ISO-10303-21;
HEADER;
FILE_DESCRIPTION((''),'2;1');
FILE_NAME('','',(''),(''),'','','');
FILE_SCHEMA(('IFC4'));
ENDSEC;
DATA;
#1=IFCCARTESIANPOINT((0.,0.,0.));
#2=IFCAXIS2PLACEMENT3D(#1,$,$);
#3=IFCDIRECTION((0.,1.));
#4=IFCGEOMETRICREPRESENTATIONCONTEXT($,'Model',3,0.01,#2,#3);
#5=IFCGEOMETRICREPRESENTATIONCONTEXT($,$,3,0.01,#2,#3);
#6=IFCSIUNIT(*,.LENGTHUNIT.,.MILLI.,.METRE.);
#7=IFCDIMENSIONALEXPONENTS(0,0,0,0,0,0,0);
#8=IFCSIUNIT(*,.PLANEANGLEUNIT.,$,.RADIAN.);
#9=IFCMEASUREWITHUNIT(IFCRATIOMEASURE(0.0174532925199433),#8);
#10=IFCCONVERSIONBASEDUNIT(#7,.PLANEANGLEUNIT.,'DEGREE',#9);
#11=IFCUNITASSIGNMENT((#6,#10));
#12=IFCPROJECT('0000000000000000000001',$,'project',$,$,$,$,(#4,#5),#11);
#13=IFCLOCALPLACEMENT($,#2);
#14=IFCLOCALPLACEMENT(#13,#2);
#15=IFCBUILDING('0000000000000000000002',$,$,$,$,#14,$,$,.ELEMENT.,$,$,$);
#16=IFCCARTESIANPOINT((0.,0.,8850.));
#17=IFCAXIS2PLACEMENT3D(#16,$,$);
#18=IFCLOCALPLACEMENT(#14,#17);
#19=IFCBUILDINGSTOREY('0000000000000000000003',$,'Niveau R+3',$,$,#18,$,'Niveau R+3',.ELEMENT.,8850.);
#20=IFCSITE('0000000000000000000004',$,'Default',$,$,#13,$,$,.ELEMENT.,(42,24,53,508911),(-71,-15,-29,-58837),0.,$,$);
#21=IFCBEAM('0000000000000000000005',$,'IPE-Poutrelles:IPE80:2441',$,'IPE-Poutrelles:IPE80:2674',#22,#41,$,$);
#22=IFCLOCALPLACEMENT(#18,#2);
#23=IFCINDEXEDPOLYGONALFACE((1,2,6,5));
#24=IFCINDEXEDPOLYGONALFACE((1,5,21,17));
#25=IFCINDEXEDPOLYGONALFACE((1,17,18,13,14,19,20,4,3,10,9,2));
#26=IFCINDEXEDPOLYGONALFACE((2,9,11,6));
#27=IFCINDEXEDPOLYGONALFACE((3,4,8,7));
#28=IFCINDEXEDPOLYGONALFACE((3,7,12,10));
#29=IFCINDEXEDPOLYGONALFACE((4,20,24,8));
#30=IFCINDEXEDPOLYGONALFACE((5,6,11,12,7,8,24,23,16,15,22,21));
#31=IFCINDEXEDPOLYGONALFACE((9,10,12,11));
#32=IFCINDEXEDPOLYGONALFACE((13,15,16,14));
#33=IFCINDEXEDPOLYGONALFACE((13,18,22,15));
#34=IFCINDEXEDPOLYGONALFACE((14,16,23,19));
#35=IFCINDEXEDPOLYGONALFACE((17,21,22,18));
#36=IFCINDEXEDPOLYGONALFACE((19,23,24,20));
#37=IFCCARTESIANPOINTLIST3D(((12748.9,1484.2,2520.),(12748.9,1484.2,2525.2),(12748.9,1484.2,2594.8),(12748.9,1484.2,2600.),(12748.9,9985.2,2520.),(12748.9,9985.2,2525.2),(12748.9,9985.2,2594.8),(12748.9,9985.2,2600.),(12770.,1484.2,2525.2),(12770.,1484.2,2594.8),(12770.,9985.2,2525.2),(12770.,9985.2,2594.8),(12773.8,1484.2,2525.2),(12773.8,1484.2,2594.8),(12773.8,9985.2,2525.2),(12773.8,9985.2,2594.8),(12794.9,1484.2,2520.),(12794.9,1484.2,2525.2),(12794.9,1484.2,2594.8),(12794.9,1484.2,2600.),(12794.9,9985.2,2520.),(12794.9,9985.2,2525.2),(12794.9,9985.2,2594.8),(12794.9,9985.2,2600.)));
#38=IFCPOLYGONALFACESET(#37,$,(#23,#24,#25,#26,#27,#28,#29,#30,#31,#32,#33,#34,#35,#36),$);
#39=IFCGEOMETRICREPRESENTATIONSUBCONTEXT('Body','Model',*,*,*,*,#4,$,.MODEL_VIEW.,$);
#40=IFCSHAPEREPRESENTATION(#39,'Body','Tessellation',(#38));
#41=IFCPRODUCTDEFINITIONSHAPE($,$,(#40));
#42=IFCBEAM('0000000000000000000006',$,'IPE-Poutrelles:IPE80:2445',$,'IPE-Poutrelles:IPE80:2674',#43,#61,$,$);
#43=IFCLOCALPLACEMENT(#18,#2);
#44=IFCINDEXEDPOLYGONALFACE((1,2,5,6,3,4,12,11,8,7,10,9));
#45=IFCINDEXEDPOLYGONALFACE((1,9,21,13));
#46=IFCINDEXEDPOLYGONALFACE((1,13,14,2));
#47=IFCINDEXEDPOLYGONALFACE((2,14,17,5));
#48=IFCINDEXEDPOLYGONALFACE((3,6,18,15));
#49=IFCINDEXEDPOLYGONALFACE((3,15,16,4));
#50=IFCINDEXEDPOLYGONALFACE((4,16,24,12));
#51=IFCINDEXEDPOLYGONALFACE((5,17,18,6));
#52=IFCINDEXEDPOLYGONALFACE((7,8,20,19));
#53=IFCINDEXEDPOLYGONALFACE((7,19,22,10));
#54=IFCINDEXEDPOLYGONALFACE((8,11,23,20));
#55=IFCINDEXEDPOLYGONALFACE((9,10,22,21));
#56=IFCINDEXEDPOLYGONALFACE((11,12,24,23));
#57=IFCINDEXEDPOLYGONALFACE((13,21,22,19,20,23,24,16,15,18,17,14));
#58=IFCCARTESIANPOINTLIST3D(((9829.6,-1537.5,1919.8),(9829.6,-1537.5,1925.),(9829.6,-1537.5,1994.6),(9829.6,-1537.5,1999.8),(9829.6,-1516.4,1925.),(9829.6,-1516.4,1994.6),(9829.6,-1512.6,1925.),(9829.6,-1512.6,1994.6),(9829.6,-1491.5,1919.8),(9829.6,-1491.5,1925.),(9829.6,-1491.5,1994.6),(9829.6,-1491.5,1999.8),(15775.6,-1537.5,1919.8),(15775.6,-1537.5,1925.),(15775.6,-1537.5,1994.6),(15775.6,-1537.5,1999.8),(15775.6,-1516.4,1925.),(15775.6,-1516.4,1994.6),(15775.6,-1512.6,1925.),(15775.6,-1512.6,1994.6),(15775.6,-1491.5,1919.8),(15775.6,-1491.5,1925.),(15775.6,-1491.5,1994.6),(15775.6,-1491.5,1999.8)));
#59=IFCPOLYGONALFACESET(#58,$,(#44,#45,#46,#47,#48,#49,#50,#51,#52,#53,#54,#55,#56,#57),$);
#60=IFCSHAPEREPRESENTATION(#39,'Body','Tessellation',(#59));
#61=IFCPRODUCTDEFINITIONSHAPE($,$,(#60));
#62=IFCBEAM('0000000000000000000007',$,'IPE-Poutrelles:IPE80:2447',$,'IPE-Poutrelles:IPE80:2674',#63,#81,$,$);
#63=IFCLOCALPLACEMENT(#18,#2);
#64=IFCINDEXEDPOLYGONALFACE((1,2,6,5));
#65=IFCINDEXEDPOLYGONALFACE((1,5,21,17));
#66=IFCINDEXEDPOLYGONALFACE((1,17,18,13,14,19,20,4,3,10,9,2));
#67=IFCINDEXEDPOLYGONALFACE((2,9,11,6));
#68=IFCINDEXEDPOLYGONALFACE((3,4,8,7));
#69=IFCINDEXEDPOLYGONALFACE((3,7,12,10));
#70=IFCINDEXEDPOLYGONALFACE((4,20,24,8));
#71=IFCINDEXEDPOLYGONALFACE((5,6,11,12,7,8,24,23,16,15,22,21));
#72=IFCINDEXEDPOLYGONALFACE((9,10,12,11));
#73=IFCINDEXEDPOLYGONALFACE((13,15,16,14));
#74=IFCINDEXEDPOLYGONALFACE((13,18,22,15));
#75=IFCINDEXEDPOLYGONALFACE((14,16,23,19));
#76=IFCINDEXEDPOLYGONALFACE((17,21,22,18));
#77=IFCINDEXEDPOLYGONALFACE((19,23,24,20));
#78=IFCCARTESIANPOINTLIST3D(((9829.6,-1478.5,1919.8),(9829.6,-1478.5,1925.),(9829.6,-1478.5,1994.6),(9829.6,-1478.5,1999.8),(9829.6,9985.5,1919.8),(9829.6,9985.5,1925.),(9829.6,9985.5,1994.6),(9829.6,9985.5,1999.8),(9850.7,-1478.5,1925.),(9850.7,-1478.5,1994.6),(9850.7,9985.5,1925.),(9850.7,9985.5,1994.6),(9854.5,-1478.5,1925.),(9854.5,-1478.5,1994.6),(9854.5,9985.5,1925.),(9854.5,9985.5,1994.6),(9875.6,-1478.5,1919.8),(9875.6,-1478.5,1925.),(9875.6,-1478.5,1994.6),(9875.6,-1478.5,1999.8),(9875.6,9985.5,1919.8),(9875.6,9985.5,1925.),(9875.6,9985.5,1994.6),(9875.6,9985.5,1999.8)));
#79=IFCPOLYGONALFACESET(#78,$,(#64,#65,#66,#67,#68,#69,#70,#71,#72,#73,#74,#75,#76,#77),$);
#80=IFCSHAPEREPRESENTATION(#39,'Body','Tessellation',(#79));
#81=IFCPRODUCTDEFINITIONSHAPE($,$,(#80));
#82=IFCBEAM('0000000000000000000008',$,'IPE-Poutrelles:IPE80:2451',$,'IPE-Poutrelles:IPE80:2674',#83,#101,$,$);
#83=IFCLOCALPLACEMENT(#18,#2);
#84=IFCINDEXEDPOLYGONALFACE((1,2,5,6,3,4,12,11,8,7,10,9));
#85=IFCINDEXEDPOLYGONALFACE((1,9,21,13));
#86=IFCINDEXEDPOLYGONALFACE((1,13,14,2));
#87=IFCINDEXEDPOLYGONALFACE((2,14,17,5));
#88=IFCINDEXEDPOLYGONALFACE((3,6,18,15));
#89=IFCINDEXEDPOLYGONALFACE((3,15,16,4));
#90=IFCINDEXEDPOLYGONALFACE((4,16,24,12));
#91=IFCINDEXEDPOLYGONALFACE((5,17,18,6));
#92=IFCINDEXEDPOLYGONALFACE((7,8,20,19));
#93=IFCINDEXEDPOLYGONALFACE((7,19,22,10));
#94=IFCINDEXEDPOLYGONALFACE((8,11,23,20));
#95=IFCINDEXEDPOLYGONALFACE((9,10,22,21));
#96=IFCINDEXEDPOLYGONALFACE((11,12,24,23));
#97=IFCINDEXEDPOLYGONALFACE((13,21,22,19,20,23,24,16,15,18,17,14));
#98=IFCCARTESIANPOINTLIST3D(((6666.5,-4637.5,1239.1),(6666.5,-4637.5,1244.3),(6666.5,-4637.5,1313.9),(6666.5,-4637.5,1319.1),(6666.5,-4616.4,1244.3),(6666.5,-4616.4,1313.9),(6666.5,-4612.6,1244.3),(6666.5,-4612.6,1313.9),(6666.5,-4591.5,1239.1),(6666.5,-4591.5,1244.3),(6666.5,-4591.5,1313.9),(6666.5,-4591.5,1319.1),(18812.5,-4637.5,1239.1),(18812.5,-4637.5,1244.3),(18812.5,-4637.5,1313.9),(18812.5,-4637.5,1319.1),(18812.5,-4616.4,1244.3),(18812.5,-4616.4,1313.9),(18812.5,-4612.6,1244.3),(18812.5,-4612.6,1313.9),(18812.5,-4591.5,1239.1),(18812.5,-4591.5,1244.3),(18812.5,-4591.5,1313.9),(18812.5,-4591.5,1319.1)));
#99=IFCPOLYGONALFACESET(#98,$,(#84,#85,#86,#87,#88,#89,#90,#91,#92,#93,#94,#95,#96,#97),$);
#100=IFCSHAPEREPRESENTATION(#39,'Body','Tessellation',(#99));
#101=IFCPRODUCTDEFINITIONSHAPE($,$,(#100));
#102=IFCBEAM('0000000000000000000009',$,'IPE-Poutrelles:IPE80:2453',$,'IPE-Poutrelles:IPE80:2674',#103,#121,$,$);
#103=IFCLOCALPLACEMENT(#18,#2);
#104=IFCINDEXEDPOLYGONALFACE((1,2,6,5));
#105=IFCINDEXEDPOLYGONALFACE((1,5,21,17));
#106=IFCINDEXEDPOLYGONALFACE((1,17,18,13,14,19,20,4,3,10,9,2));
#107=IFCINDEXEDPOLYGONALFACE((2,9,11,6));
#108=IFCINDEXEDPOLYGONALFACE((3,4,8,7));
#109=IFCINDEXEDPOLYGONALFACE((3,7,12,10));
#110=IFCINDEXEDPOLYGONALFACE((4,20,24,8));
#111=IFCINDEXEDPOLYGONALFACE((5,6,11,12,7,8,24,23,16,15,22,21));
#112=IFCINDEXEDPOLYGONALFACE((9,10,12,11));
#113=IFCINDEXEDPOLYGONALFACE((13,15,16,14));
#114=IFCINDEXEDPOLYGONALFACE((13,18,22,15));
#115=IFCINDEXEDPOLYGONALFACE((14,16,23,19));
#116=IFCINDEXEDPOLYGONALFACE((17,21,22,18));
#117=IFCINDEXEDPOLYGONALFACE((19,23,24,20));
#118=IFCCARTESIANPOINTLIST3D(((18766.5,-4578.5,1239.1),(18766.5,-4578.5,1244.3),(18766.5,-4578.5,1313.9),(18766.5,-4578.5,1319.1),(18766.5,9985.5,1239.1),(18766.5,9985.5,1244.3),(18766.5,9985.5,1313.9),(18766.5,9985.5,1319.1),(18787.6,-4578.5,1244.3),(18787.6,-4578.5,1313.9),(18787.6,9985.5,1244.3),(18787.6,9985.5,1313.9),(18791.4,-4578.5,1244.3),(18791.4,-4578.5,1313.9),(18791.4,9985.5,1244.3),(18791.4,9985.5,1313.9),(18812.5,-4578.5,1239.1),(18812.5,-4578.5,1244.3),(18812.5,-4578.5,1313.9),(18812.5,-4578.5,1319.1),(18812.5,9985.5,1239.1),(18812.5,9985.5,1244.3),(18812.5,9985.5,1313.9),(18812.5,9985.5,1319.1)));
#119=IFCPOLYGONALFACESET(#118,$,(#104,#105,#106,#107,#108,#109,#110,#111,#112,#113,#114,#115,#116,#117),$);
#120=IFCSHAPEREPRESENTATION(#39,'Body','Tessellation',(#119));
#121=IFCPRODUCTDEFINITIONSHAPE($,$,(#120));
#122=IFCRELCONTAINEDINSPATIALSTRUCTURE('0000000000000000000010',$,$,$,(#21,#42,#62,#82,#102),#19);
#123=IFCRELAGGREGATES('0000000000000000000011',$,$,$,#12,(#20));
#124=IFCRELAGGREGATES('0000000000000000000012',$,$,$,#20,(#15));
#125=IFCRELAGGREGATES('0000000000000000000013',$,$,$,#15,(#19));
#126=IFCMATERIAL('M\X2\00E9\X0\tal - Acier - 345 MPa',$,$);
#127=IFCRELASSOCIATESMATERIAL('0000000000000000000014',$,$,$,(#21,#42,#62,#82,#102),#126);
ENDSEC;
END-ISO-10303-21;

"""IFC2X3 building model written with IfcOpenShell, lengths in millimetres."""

from ifc_helpers import new_model, entity, si_unit, converted_unit, direction, frame, frame_2d, origin, place, context, subcontext, project, spatial, i_section, extrude, material, element, save


model = new_model("IFC2X3")

# Units and contexts
model_context = context("Model", 3, precision=0.01, world=origin(), true_north=direction((0.0, 1.0)))
context_of_model = context(None, 3, precision=0.01, world=origin(), true_north=direction((0.0, 1.0)))
body_context = subcontext(model_context, "Body", "Model", "MODEL_VIEW")
ifc_project = project(units=[si_unit("LENGTHUNIT", "METRE", prefix="MILLI"), converted_unit("PLANEANGLEUNIT", "DEGREE", entity("IfcRatioMeasure", 0.0174532925199433), si_unit("PLANEANGLEUNIT", "RADIAN"), dimensions=[0, 0, 0, 0, 0, 0, 0])], contexts=[model_context, context_of_model])

# Site, building, storey
site_placement = place(None, origin())
site = spatial("IfcSite", under=ifc_project, at=site_placement, Name="Default", CompositionType="ELEMENT", RefLatitude=(42, 24, 53, 508911), RefLongitude=(-71, -15, -29, -58837), RefElevation=0.0)
building_placement = place(site_placement, origin())
building = spatial("IfcBuilding", under=site, at=building_placement, CompositionType="ELEMENT")
storey_placement = place(building_placement, frame((0.0, 0.0, 8850.0)))
storey = spatial("IfcBuildingStorey", under=building, at=storey_placement, Name="Niveau R+3", LongName="Niveau R+3", CompositionType="ELEMENT", Elevation=8850.0)

# Shared definitions
ifc_material = material(Name="Métal - Acier - 345 MPa")

# Beams
beam_1_placement = place(storey_placement, frame((12771.9, 1447.0, 2600.0), z_axis=(0.0, 0.0, 1.0), x_axis=(0.0, 1.0, 0.0)))
element("IfcBeam", 1, at=beam_1_placement, inside=storey, material=ifc_material, Name="IPE-Poutrelles:IPE80:2441", ObjectType="IPE-Poutrelles:IPE80:2674", context=body_context, shape_type="SweptSolid", body=[
    extrude(i_section(OverallWidth=46.0, OverallDepth=80.0, WebThickness=3.8, FlangeThickness=5.2, at=frame_2d((0.0, 0.0), x_axis=(0.0, 1.0))), frame((37.2, 0.0, -40.0), z_axis=(1.0, 0.0, 0.0), x_axis=(0.0, 0.0, -1.0)), (0.0, 0.0, 1.0), 8501.0),
])
beam_2_placement = place(storey_placement, frame((15752.6, -1514.5, 1999.8), z_axis=(0.0, 0.0, 1.0), x_axis=(-1.0, 0.0, 0.0)))
element("IfcBeam", 2, at=beam_2_placement, inside=storey, material=ifc_material, Name="IPE-Poutrelles:IPE80:2445", ObjectType="IPE-Poutrelles:IPE80:2674", context=body_context, shape_type="SweptSolid", body=[
    extrude(i_section(OverallWidth=46.0, OverallDepth=80.0, WebThickness=3.8, FlangeThickness=5.2, at=frame_2d((0.0, 0.0), x_axis=(0.0, 1.0))), frame((-23.0, 0.0, -40.0), z_axis=(1.0, 0.0, 0.0), x_axis=(0.0, 0.0, -1.0)), (0.0, 0.0, 1.0), 5946.0),
])
beam_3_placement = place(storey_placement, frame((9852.6, -1514.5, 1999.8), z_axis=(0.0, 0.0, 1.0), x_axis=(0.0, 1.0, 0.0)))
element("IfcBeam", 3, at=beam_3_placement, inside=storey, material=ifc_material, Name="IPE-Poutrelles:IPE80:2447", ObjectType="IPE-Poutrelles:IPE80:2674", context=body_context, shape_type="SweptSolid", body=[
    extrude(i_section(OverallWidth=46.0, OverallDepth=80.0, WebThickness=3.8, FlangeThickness=5.2, at=frame_2d((0.0, 0.0), x_axis=(0.0, 1.0))), frame((36.0, 0.0, -40.0), z_axis=(1.0, 0.0, 0.0), x_axis=(0.0, 0.0, -1.0)), (0.0, 0.0, 1.0), 11464.0),
])
beam_4_placement = place(storey_placement, frame((6689.5, -4614.5, 1319.1)))
element("IfcBeam", 4, at=beam_4_placement, inside=storey, material=ifc_material, Name="IPE-Poutrelles:IPE80:2451", ObjectType="IPE-Poutrelles:IPE80:2674", context=body_context, shape_type="SweptSolid", body=[
    extrude(i_section(OverallWidth=46.0, OverallDepth=80.0, WebThickness=3.8, FlangeThickness=5.2, at=frame_2d((0.0, 0.0), x_axis=(0.0, 1.0))), frame((-23.0, 0.0, -40.0), z_axis=(1.0, 0.0, 0.0), x_axis=(0.0, 0.0, -1.0)), (0.0, 0.0, 1.0), 12146.0),
])
beam_5_placement = place(storey_placement, frame((18789.5, -4614.5, 1319.1), z_axis=(0.0, 0.0, 1.0), x_axis=(0.0, 1.0, 0.0)))
element("IfcBeam", 5, at=beam_5_placement, inside=storey, material=ifc_material, Name="IPE-Poutrelles:IPE80:2453", ObjectType="IPE-Poutrelles:IPE80:2674", context=body_context, shape_type="SweptSolid", body=[
    extrude(i_section(OverallWidth=46.0, OverallDepth=80.0, WebThickness=3.8, FlangeThickness=5.2, at=frame_2d((0.0, 0.0), x_axis=(0.0, 1.0))), frame((36.0, 0.0, -40.0), z_axis=(1.0, 0.0, 0.0), x_axis=(0.0, 0.0, -1.0)), (0.0, 0.0, 1.0), 14564.0),
])

save(model, "model.ifc")
